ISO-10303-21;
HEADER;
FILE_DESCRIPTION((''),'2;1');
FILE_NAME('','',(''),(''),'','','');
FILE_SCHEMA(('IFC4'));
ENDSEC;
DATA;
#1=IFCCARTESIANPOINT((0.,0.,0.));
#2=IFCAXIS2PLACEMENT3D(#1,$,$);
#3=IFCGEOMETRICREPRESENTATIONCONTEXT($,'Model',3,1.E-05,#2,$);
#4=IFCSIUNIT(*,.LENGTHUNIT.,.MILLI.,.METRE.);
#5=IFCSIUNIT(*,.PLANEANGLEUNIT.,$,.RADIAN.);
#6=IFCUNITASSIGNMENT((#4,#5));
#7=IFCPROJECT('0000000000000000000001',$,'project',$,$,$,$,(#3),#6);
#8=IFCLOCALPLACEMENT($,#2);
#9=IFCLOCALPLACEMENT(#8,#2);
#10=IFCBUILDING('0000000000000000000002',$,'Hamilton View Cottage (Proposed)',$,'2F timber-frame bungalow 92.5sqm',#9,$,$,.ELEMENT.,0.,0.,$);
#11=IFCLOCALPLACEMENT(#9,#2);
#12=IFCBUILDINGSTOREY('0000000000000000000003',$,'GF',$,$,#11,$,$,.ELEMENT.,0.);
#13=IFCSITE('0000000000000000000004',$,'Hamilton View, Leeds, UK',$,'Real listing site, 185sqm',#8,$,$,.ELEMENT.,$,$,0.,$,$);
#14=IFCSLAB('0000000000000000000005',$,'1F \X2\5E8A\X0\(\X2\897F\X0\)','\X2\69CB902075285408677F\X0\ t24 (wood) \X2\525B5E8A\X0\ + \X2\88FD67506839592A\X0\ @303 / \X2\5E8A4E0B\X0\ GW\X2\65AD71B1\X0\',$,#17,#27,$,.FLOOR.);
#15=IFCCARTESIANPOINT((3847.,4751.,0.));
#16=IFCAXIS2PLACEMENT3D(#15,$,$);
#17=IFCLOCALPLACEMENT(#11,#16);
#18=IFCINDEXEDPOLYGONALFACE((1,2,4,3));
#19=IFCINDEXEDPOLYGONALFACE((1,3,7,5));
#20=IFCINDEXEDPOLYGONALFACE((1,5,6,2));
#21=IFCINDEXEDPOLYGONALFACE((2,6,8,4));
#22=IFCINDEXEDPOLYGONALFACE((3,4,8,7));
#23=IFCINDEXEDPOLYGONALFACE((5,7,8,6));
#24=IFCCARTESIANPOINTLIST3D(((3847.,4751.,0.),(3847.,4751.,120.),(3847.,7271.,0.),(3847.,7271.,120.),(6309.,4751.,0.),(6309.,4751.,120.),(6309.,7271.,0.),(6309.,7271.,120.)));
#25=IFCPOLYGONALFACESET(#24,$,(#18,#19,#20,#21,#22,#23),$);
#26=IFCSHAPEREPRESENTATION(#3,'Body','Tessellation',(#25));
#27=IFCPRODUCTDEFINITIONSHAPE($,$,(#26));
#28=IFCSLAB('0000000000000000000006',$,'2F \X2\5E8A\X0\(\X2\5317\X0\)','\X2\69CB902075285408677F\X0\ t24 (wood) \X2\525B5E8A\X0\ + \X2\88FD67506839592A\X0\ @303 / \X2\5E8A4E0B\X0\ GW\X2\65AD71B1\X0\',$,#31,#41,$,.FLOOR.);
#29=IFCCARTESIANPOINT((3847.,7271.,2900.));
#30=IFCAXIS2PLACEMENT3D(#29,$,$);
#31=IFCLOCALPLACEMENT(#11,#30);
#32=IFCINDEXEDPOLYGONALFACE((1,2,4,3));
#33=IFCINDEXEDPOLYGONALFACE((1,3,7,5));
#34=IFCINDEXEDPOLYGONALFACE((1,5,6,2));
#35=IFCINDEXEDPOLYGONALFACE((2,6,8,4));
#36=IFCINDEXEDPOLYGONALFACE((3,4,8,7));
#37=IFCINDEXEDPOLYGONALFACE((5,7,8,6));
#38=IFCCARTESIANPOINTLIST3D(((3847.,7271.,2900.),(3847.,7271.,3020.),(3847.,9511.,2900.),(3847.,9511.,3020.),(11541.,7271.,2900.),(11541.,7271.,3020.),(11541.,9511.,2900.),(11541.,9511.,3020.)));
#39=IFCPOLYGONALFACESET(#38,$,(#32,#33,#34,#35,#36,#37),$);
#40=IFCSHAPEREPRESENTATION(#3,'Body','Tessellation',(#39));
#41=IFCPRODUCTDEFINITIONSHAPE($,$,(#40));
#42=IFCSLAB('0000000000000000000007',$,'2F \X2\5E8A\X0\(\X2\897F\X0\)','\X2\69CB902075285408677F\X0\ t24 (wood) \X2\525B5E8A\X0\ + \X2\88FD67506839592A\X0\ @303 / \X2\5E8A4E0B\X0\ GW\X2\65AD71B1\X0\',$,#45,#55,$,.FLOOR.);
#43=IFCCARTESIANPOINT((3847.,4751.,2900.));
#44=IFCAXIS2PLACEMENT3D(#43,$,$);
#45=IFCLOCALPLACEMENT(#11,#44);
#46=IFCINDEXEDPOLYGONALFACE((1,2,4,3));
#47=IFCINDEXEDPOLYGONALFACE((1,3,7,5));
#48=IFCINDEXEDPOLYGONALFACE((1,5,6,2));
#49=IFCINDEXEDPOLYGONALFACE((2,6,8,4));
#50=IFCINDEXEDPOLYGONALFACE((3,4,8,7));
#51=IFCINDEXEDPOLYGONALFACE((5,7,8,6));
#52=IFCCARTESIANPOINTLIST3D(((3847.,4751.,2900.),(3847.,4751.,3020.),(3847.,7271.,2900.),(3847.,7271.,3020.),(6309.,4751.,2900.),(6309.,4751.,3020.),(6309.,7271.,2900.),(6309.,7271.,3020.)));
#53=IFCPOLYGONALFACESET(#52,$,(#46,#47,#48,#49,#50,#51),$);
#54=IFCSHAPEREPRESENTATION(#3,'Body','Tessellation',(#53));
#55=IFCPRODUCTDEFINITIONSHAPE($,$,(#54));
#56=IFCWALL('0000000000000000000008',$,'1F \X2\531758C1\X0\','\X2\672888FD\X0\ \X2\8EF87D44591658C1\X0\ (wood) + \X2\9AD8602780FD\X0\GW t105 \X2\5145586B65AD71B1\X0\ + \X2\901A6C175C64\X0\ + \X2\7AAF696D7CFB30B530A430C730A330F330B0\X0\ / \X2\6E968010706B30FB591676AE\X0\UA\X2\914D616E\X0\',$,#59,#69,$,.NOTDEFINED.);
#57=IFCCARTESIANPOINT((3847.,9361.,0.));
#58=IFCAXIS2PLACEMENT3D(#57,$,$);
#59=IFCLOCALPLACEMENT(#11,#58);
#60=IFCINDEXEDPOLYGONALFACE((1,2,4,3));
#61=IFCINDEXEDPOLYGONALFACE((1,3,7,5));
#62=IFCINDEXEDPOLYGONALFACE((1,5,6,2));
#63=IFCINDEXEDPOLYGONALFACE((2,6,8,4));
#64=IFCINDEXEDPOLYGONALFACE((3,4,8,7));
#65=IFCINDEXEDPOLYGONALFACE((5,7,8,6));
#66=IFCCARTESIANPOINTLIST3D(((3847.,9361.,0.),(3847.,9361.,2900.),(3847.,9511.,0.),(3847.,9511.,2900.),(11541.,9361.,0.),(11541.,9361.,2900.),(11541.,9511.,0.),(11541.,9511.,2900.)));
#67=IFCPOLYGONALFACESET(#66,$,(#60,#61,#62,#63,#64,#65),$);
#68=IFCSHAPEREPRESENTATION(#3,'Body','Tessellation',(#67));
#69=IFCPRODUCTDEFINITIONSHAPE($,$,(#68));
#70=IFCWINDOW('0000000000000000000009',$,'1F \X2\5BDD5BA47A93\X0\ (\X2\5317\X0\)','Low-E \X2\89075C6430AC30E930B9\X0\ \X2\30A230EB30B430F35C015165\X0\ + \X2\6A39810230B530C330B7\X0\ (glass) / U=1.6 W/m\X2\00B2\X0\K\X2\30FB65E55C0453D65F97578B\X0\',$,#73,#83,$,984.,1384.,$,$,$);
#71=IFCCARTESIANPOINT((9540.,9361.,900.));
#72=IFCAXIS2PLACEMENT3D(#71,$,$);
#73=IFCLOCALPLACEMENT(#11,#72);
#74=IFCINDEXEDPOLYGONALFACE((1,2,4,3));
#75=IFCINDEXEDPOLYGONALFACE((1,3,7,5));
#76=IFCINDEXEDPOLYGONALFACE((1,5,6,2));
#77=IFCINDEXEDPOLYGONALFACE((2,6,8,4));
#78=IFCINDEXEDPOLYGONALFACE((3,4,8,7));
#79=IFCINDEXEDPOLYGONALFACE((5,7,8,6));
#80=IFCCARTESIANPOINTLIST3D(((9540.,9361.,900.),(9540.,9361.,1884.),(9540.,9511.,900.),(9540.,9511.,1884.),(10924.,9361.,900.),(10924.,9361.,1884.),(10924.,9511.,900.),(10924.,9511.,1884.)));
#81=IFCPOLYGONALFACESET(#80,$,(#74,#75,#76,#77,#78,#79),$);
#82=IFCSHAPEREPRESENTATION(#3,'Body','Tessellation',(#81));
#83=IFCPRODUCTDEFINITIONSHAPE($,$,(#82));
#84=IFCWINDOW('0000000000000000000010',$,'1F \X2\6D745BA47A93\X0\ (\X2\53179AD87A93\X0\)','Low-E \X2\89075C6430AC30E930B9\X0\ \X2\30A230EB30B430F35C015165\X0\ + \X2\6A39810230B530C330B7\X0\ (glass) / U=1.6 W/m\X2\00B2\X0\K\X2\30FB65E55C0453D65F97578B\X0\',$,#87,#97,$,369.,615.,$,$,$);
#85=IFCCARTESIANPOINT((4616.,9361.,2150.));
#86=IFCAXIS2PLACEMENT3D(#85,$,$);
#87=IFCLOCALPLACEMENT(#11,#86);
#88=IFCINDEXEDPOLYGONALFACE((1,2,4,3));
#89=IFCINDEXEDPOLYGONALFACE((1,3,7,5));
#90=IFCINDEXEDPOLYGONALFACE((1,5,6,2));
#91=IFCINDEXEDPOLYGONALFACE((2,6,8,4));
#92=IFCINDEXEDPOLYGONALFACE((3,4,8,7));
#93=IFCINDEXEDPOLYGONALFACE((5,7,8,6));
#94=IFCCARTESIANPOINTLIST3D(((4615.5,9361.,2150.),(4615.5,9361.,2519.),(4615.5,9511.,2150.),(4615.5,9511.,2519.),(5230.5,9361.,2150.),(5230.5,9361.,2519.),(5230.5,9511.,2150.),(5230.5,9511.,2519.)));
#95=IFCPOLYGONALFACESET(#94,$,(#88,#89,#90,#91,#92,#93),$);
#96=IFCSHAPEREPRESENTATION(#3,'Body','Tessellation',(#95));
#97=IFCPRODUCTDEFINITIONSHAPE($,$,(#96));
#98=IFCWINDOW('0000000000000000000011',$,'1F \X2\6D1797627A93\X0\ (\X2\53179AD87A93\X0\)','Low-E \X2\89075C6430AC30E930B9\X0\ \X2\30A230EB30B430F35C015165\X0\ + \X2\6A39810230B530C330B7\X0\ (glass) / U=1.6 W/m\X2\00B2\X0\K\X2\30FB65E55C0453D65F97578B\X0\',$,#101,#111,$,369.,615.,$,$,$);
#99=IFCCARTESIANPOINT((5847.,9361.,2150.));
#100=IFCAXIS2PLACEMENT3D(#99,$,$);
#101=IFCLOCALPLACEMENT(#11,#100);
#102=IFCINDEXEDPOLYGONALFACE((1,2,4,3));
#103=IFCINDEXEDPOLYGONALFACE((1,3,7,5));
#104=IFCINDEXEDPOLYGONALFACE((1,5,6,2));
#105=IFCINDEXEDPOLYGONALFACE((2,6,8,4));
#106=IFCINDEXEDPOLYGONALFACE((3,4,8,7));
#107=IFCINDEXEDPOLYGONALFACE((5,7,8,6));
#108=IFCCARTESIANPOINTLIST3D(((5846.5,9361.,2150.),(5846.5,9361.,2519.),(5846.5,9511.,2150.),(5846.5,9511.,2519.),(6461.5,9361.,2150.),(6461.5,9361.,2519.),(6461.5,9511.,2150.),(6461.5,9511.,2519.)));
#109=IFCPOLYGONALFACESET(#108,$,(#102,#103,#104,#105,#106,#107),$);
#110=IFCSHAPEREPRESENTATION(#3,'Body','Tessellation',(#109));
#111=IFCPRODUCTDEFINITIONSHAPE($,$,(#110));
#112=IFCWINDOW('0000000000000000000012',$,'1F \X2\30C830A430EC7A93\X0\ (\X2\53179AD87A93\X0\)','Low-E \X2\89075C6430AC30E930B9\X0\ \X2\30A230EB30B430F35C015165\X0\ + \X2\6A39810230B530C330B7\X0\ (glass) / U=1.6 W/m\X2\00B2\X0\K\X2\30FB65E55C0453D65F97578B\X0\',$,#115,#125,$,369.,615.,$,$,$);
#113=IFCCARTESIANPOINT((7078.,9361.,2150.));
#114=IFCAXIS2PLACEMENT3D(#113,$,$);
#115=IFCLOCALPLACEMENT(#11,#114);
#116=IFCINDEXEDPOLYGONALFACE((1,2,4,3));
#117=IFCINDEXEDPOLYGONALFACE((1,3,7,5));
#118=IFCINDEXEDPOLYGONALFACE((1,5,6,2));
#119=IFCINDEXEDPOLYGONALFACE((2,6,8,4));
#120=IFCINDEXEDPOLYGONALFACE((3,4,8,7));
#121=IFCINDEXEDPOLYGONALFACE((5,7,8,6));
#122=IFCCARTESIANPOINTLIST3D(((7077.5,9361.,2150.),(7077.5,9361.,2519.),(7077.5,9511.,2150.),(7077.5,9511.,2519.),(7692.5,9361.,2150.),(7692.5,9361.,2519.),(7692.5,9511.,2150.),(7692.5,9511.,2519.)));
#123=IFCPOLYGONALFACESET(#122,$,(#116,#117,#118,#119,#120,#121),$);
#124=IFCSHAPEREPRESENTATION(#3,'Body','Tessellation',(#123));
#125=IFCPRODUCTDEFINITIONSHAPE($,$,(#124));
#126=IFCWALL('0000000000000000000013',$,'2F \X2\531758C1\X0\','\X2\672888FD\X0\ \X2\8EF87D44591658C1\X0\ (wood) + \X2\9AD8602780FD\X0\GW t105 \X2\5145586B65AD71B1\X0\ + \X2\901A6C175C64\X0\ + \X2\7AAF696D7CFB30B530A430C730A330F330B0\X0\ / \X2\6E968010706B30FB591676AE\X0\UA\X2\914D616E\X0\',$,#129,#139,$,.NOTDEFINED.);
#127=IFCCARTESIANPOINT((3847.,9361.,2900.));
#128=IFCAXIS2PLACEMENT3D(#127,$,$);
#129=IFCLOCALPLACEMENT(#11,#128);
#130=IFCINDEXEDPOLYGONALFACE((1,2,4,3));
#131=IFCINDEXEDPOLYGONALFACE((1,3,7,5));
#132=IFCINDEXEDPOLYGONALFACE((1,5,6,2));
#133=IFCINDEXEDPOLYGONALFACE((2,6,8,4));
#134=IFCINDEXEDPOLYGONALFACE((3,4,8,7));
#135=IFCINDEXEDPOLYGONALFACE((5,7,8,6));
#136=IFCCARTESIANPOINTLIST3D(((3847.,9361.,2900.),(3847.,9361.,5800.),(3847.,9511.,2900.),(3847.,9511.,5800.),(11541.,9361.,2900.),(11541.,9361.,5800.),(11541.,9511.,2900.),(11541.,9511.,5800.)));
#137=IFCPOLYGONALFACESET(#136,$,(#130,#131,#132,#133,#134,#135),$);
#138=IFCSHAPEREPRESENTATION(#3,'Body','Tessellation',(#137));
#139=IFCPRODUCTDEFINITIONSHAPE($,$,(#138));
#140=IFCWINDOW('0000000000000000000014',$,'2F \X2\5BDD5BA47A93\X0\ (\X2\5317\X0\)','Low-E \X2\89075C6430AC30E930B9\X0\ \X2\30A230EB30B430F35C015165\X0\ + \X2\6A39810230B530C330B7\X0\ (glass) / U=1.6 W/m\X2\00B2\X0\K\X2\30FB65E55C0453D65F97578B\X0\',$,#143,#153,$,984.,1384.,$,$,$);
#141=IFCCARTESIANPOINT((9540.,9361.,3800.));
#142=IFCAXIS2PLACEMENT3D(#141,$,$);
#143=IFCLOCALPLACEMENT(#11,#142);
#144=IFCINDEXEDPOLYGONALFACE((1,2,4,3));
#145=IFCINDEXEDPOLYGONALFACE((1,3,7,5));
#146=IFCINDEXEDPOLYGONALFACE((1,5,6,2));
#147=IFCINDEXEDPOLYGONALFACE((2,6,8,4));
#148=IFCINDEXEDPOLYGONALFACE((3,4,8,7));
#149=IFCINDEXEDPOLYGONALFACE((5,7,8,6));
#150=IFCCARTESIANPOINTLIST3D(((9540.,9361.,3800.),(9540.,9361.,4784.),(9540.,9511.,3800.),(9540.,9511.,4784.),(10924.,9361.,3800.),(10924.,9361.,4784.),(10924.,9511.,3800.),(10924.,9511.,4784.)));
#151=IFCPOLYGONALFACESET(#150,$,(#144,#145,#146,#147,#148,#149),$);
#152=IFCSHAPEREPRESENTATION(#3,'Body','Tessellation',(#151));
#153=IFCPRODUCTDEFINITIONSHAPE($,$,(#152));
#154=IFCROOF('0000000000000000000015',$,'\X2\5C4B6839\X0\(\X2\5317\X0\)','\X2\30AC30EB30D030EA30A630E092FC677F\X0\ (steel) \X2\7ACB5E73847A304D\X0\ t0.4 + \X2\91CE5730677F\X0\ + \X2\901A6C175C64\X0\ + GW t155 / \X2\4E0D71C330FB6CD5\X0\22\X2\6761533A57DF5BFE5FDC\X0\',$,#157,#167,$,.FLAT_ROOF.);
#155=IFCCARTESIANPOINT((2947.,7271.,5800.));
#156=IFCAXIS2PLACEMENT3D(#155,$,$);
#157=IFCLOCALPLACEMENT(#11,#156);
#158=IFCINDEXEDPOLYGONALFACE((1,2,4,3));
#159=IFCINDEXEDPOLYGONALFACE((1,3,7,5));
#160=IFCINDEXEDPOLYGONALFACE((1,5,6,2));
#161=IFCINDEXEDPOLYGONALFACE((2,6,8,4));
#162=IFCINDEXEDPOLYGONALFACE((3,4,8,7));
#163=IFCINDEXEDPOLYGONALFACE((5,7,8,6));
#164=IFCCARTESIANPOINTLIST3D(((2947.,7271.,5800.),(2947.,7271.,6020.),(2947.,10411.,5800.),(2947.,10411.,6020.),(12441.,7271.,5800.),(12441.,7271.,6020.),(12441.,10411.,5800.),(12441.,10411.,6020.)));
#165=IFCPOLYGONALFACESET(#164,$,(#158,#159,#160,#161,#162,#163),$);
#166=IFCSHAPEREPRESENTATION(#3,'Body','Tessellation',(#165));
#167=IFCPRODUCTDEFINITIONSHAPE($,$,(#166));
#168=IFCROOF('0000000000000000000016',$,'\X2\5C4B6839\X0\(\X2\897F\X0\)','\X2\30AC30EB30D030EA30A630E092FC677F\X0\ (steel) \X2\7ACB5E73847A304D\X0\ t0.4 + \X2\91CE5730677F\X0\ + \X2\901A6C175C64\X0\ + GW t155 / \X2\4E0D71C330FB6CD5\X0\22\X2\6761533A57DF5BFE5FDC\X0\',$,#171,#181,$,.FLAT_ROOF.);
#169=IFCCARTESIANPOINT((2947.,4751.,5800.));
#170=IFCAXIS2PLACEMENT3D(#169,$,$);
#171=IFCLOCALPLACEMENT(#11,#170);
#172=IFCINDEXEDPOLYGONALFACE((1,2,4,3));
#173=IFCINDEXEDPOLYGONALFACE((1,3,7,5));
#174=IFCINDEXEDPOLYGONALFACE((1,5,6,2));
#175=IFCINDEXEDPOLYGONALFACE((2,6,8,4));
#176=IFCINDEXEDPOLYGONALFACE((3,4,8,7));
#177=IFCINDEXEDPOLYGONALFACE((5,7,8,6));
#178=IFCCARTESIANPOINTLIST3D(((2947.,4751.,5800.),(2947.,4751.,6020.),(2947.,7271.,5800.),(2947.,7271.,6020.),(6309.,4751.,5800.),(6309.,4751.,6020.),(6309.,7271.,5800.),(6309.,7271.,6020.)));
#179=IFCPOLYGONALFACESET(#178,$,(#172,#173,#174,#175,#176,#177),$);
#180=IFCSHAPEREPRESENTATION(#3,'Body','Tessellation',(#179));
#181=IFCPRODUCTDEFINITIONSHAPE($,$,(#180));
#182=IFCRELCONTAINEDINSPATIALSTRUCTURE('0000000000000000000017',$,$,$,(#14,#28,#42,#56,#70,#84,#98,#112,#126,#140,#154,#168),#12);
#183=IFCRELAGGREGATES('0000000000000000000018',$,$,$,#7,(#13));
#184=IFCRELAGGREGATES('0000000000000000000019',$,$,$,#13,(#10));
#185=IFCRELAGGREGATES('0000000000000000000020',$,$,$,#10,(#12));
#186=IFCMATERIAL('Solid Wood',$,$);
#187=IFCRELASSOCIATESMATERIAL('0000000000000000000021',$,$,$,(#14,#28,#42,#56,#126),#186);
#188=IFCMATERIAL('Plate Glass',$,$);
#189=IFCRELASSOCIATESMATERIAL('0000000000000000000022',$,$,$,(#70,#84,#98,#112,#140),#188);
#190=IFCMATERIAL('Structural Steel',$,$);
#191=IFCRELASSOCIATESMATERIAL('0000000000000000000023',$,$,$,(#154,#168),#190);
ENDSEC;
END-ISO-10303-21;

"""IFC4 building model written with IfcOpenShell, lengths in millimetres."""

from ifc_helpers import new_model, si_unit, frame, frame_2d, origin, place, context, project, spatial, rectangle, extrude, material, element, fill, save


model = new_model("IFC4")

# Units and contexts
model_context = context("Model", 3, precision=1e-05, world=origin())
ifc_project = project(units=[si_unit("LENGTHUNIT", "METRE", prefix="MILLI"), si_unit("PLANEANGLEUNIT", "RADIAN")], contexts=[model_context])

# Site, building, storey
site_placement = place(None, origin())
site = spatial("IfcSite", under=ifc_project, at=site_placement, Name="Hamilton View, Leeds, UK", ObjectType="Real listing site, 185sqm", CompositionType="ELEMENT", RefElevation=0.0)
building_placement = place(site_placement, origin())
building = spatial("IfcBuilding", under=site, at=building_placement, Name="Hamilton View Cottage (Proposed)", ObjectType="2F timber-frame bungalow 92.5sqm", CompositionType="ELEMENT", ElevationOfRefHeight=0.0, ElevationOfTerrain=0.0)
storey_placement = place(building_placement, origin())
storey = spatial("IfcBuildingStorey", under=building, at=storey_placement, Name="GF", CompositionType="ELEMENT", Elevation=0.0)

# Slabs
ifc_material_1 = material(Name="Solid Wood")
slab_1_placement = place(storey_placement, frame((3847.0, 4751.0, 0.0)))
element("IfcSlab", 1, at=slab_1_placement, inside=storey, material=ifc_material_1, Name="1F 床(西)", Description="構造用合板 t24 (wood) 剛床 + 製材根太 @303 / 床下 GW断熱", PredefinedType="FLOOR", context=model_context, shape_type="SweptSolid", body=[
    extrude(rectangle(XDim=2462.0, YDim=2520.0, at=frame_2d((1231.0, 1260.0))), frame((3847.0, 4751.0, 0.0)), (0.0, 0.0, 1.0), 120.0),
])
slab_2_placement = place(storey_placement, frame((3847.0, 7271.0, 2900.0)))
element("IfcSlab", 2, at=slab_2_placement, inside=storey, material=ifc_material_1, Name="2F 床(北)", Description="構造用合板 t24 (wood) 剛床 + 製材根太 @303 / 床下 GW断熱", PredefinedType="FLOOR", context=model_context, shape_type="SweptSolid", body=[
    extrude(rectangle(XDim=7694.0, YDim=2240.0, at=frame_2d((3847.0, 1120.0))), frame((3847.0, 7271.0, 2900.0)), (0.0, 0.0, 1.0), 120.0),
])
slab_3_placement = place(storey_placement, frame((3847.0, 4751.0, 2900.0)))
element("IfcSlab", 3, at=slab_3_placement, inside=storey, material=ifc_material_1, Name="2F 床(西)", Description="構造用合板 t24 (wood) 剛床 + 製材根太 @303 / 床下 GW断熱", PredefinedType="FLOOR", context=model_context, shape_type="SweptSolid", body=[
    extrude(rectangle(XDim=2462.0, YDim=2520.0, at=frame_2d((1231.0, 1260.0))), frame((3847.0, 4751.0, 2900.0)), (0.0, 0.0, 1.0), 120.0),
])

# Wall, openings, windows
wall_1_placement = place(storey_placement, frame((3847.0, 9361.0, 0.0)))
wall_1 = element("IfcWall", 4, at=wall_1_placement, inside=storey, material=ifc_material_1, Name="1F 北壁", Description="木製 軸組外壁 (wood) + 高性能GW t105 充填断熱 + 通気層 + 窯業系サイディング / 準耐火・外皮UA配慮", PredefinedType="NOTDEFINED", context=model_context, shape_type="SweptSolid", body=[
    extrude(rectangle(XDim=7694.0, YDim=150.0, at=frame_2d((3847.0, 75.0))), frame((3847.0, 9361.0, 0.0)), (0.0, 0.0, 1.0), 2900.0),
])
opening_1_placement = place(storey_placement, frame((9540.0, 9361.0, 900.0)))
opening_1 = element("IfcOpeningElement", 5, at=opening_1_placement, cuts=wall_1, PredefinedType="NOTDEFINED", context=model_context, shape_type="SweptSolid", body=[
    extrude(rectangle(XDim=1384.0, YDim=150.0, at=frame_2d((692.0, 75.0))), frame((9540.0, 9361.0, 900.0)), (0.0, 0.0, 1.0), 984.0),
])
opening_2_placement = place(storey_placement, frame((4616.0, 9361.0, 2150.0)))
opening_2 = element("IfcOpeningElement", 6, at=opening_2_placement, cuts=wall_1, PredefinedType="NOTDEFINED", context=model_context, shape_type="SweptSolid", body=[
    extrude(rectangle(XDim=615.0, YDim=150.0, at=frame_2d((307.0, 75.0))), frame((4616.0, 9361.0, 2150.0)), (0.0, 0.0, 1.0), 369.0),
])
opening_3_placement = place(storey_placement, frame((5847.0, 9361.0, 2150.0)))
opening_3 = element("IfcOpeningElement", 7, at=opening_3_placement, cuts=wall_1, PredefinedType="NOTDEFINED", context=model_context, shape_type="SweptSolid", body=[
    extrude(rectangle(XDim=615.0, YDim=150.0, at=frame_2d((307.0, 75.0))), frame((5847.0, 9361.0, 2150.0)), (0.0, 0.0, 1.0), 369.0),
])
opening_4_placement = place(storey_placement, frame((7078.0, 9361.0, 2150.0)))
opening_4 = element("IfcOpeningElement", 8, at=opening_4_placement, cuts=wall_1, PredefinedType="NOTDEFINED", context=model_context, shape_type="SweptSolid", body=[
    extrude(rectangle(XDim=615.0, YDim=150.0, at=frame_2d((307.0, 75.0))), frame((7078.0, 9361.0, 2150.0)), (0.0, 0.0, 1.0), 369.0),
])
ifc_material_2 = material(Name="Plate Glass")
window_1_placement = place(storey_placement, frame((9540.0, 9361.0, 900.0)))
window_1 = element("IfcWindow", 9, at=window_1_placement, inside=storey, material=ifc_material_2, Name="1F 寝室窓 (北)", Description="Low-E 複層ガラス アルゴン封入 + 樹脂サッシ (glass) / U=1.6 W/m²K・日射取得型", OverallHeight=984.0, OverallWidth=1384.0, context=model_context, shape_type="SweptSolid", body=[
    extrude(rectangle(XDim=1384.0, YDim=150.0, at=frame_2d((692.0, 75.0))), frame((9540.0, 9361.0, 900.0)), (0.0, 0.0, 1.0), 984.0),
])
fill(opening_1, window_1)
window_2_placement = place(storey_placement, frame((4616.0, 9361.0, 2150.0)))
window_2 = element("IfcWindow", 10, at=window_2_placement, inside=storey, material=ifc_material_2, Name="1F 浴室窓 (北高窓)", Description="Low-E 複層ガラス アルゴン封入 + 樹脂サッシ (glass) / U=1.6 W/m²K・日射取得型", OverallHeight=369.0, OverallWidth=615.0, context=model_context, shape_type="SweptSolid", body=[
    extrude(rectangle(XDim=615.0, YDim=150.0, at=frame_2d((307.0, 75.0))), frame((4616.0, 9361.0, 2150.0)), (0.0, 0.0, 1.0), 369.0),
])
fill(opening_2, window_2)
window_3_placement = place(storey_placement, frame((5847.0, 9361.0, 2150.0)))
window_3 = element("IfcWindow", 11, at=window_3_placement, inside=storey, material=ifc_material_2, Name="1F 洗面窓 (北高窓)", Description="Low-E 複層ガラス アルゴン封入 + 樹脂サッシ (glass) / U=1.6 W/m²K・日射取得型", OverallHeight=369.0, OverallWidth=615.0, context=model_context, shape_type="SweptSolid", body=[
    extrude(rectangle(XDim=615.0, YDim=150.0, at=frame_2d((307.0, 75.0))), frame((5847.0, 9361.0, 2150.0)), (0.0, 0.0, 1.0), 369.0),
])
fill(opening_3, window_3)
window_4_placement = place(storey_placement, frame((7078.0, 9361.0, 2150.0)))
window_4 = element("IfcWindow", 12, at=window_4_placement, inside=storey, material=ifc_material_2, Name="1F トイレ窓 (北高窓)", Description="Low-E 複層ガラス アルゴン封入 + 樹脂サッシ (glass) / U=1.6 W/m²K・日射取得型", OverallHeight=369.0, OverallWidth=615.0, context=model_context, shape_type="SweptSolid", body=[
    extrude(rectangle(XDim=615.0, YDim=150.0, at=frame_2d((307.0, 75.0))), frame((7078.0, 9361.0, 2150.0)), (0.0, 0.0, 1.0), 369.0),
])
fill(opening_4, window_4)

# Wall, opening, window
wall_2_placement = place(storey_placement, frame((3847.0, 9361.0, 2900.0)))
wall_2 = element("IfcWall", 13, at=wall_2_placement, inside=storey, material=ifc_material_1, Name="2F 北壁", Description="木製 軸組外壁 (wood) + 高性能GW t105 充填断熱 + 通気層 + 窯業系サイディング / 準耐火・外皮UA配慮", PredefinedType="NOTDEFINED", context=model_context, shape_type="SweptSolid", body=[
    extrude(rectangle(XDim=7694.0, YDim=150.0, at=frame_2d((3847.0, 75.0))), frame((3847.0, 9361.0, 2900.0)), (0.0, 0.0, 1.0), 2900.0),
])
opening_5_placement = place(storey_placement, frame((9540.0, 9361.0, 3800.0)))
opening_5 = element("IfcOpeningElement", 14, at=opening_5_placement, cuts=wall_2, PredefinedType="NOTDEFINED", context=model_context, shape_type="SweptSolid", body=[
    extrude(rectangle(XDim=1384.0, YDim=150.0, at=frame_2d((692.0, 75.0))), frame((9540.0, 9361.0, 3800.0)), (0.0, 0.0, 1.0), 984.0),
])
window_5_placement = place(storey_placement, frame((9540.0, 9361.0, 3800.0)))
window_5 = element("IfcWindow", 15, at=window_5_placement, inside=storey, material=ifc_material_2, Name="2F 寝室窓 (北)", Description="Low-E 複層ガラス アルゴン封入 + 樹脂サッシ (glass) / U=1.6 W/m²K・日射取得型", OverallHeight=984.0, OverallWidth=1384.0, context=model_context, shape_type="SweptSolid", body=[
    extrude(rectangle(XDim=1384.0, YDim=150.0, at=frame_2d((692.0, 75.0))), frame((9540.0, 9361.0, 3800.0)), (0.0, 0.0, 1.0), 984.0),
])
fill(opening_5, window_5)

# Roofs
ifc_material_3 = material(Name="Structural Steel")
for number, where, name in (
    (16, (2947.0, 7271.0, 5800.0), "屋根(北)"),
):
    element("IfcRoof", number, at=place(storey_placement, frame(where)), inside=storey, material=ifc_material_3, Name=name, Description="ガルバリウム鋼板 (steel) 立平葺き t0.4 + 野地板 + 通気層 + GW t155 / 不燃・法22条区域対応", PredefinedType="FLAT_ROOF", context=model_context, shape_type="SweptSolid", body=[
        extrude(rectangle(XDim=9494.0, YDim=3140.0, at=frame_2d((4747.0, 1570.0))), frame((2947.0, 7271.0, 5800.0)), (0.0, 0.0, 1.0), 220.0),
    ])
roof_placement = place(storey_placement, frame((2947.0, 4751.0, 5800.0)))
element("IfcRoof", 17, at=roof_placement, inside=storey, material=ifc_material_3, Name="屋根(西)", Description="ガルバリウム鋼板 (steel) 立平葺き t0.4 + 野地板 + 通気層 + GW t155 / 不燃・法22条区域対応", PredefinedType="FLAT_ROOF", context=model_context, shape_type="SweptSolid", body=[
    extrude(rectangle(XDim=3362.0, YDim=2520.0, at=frame_2d((1681.0, 1260.0))), frame((2947.0, 4751.0, 5800.0)), (0.0, 0.0, 1.0), 220.0),
])

save(model, "model.ifc")
